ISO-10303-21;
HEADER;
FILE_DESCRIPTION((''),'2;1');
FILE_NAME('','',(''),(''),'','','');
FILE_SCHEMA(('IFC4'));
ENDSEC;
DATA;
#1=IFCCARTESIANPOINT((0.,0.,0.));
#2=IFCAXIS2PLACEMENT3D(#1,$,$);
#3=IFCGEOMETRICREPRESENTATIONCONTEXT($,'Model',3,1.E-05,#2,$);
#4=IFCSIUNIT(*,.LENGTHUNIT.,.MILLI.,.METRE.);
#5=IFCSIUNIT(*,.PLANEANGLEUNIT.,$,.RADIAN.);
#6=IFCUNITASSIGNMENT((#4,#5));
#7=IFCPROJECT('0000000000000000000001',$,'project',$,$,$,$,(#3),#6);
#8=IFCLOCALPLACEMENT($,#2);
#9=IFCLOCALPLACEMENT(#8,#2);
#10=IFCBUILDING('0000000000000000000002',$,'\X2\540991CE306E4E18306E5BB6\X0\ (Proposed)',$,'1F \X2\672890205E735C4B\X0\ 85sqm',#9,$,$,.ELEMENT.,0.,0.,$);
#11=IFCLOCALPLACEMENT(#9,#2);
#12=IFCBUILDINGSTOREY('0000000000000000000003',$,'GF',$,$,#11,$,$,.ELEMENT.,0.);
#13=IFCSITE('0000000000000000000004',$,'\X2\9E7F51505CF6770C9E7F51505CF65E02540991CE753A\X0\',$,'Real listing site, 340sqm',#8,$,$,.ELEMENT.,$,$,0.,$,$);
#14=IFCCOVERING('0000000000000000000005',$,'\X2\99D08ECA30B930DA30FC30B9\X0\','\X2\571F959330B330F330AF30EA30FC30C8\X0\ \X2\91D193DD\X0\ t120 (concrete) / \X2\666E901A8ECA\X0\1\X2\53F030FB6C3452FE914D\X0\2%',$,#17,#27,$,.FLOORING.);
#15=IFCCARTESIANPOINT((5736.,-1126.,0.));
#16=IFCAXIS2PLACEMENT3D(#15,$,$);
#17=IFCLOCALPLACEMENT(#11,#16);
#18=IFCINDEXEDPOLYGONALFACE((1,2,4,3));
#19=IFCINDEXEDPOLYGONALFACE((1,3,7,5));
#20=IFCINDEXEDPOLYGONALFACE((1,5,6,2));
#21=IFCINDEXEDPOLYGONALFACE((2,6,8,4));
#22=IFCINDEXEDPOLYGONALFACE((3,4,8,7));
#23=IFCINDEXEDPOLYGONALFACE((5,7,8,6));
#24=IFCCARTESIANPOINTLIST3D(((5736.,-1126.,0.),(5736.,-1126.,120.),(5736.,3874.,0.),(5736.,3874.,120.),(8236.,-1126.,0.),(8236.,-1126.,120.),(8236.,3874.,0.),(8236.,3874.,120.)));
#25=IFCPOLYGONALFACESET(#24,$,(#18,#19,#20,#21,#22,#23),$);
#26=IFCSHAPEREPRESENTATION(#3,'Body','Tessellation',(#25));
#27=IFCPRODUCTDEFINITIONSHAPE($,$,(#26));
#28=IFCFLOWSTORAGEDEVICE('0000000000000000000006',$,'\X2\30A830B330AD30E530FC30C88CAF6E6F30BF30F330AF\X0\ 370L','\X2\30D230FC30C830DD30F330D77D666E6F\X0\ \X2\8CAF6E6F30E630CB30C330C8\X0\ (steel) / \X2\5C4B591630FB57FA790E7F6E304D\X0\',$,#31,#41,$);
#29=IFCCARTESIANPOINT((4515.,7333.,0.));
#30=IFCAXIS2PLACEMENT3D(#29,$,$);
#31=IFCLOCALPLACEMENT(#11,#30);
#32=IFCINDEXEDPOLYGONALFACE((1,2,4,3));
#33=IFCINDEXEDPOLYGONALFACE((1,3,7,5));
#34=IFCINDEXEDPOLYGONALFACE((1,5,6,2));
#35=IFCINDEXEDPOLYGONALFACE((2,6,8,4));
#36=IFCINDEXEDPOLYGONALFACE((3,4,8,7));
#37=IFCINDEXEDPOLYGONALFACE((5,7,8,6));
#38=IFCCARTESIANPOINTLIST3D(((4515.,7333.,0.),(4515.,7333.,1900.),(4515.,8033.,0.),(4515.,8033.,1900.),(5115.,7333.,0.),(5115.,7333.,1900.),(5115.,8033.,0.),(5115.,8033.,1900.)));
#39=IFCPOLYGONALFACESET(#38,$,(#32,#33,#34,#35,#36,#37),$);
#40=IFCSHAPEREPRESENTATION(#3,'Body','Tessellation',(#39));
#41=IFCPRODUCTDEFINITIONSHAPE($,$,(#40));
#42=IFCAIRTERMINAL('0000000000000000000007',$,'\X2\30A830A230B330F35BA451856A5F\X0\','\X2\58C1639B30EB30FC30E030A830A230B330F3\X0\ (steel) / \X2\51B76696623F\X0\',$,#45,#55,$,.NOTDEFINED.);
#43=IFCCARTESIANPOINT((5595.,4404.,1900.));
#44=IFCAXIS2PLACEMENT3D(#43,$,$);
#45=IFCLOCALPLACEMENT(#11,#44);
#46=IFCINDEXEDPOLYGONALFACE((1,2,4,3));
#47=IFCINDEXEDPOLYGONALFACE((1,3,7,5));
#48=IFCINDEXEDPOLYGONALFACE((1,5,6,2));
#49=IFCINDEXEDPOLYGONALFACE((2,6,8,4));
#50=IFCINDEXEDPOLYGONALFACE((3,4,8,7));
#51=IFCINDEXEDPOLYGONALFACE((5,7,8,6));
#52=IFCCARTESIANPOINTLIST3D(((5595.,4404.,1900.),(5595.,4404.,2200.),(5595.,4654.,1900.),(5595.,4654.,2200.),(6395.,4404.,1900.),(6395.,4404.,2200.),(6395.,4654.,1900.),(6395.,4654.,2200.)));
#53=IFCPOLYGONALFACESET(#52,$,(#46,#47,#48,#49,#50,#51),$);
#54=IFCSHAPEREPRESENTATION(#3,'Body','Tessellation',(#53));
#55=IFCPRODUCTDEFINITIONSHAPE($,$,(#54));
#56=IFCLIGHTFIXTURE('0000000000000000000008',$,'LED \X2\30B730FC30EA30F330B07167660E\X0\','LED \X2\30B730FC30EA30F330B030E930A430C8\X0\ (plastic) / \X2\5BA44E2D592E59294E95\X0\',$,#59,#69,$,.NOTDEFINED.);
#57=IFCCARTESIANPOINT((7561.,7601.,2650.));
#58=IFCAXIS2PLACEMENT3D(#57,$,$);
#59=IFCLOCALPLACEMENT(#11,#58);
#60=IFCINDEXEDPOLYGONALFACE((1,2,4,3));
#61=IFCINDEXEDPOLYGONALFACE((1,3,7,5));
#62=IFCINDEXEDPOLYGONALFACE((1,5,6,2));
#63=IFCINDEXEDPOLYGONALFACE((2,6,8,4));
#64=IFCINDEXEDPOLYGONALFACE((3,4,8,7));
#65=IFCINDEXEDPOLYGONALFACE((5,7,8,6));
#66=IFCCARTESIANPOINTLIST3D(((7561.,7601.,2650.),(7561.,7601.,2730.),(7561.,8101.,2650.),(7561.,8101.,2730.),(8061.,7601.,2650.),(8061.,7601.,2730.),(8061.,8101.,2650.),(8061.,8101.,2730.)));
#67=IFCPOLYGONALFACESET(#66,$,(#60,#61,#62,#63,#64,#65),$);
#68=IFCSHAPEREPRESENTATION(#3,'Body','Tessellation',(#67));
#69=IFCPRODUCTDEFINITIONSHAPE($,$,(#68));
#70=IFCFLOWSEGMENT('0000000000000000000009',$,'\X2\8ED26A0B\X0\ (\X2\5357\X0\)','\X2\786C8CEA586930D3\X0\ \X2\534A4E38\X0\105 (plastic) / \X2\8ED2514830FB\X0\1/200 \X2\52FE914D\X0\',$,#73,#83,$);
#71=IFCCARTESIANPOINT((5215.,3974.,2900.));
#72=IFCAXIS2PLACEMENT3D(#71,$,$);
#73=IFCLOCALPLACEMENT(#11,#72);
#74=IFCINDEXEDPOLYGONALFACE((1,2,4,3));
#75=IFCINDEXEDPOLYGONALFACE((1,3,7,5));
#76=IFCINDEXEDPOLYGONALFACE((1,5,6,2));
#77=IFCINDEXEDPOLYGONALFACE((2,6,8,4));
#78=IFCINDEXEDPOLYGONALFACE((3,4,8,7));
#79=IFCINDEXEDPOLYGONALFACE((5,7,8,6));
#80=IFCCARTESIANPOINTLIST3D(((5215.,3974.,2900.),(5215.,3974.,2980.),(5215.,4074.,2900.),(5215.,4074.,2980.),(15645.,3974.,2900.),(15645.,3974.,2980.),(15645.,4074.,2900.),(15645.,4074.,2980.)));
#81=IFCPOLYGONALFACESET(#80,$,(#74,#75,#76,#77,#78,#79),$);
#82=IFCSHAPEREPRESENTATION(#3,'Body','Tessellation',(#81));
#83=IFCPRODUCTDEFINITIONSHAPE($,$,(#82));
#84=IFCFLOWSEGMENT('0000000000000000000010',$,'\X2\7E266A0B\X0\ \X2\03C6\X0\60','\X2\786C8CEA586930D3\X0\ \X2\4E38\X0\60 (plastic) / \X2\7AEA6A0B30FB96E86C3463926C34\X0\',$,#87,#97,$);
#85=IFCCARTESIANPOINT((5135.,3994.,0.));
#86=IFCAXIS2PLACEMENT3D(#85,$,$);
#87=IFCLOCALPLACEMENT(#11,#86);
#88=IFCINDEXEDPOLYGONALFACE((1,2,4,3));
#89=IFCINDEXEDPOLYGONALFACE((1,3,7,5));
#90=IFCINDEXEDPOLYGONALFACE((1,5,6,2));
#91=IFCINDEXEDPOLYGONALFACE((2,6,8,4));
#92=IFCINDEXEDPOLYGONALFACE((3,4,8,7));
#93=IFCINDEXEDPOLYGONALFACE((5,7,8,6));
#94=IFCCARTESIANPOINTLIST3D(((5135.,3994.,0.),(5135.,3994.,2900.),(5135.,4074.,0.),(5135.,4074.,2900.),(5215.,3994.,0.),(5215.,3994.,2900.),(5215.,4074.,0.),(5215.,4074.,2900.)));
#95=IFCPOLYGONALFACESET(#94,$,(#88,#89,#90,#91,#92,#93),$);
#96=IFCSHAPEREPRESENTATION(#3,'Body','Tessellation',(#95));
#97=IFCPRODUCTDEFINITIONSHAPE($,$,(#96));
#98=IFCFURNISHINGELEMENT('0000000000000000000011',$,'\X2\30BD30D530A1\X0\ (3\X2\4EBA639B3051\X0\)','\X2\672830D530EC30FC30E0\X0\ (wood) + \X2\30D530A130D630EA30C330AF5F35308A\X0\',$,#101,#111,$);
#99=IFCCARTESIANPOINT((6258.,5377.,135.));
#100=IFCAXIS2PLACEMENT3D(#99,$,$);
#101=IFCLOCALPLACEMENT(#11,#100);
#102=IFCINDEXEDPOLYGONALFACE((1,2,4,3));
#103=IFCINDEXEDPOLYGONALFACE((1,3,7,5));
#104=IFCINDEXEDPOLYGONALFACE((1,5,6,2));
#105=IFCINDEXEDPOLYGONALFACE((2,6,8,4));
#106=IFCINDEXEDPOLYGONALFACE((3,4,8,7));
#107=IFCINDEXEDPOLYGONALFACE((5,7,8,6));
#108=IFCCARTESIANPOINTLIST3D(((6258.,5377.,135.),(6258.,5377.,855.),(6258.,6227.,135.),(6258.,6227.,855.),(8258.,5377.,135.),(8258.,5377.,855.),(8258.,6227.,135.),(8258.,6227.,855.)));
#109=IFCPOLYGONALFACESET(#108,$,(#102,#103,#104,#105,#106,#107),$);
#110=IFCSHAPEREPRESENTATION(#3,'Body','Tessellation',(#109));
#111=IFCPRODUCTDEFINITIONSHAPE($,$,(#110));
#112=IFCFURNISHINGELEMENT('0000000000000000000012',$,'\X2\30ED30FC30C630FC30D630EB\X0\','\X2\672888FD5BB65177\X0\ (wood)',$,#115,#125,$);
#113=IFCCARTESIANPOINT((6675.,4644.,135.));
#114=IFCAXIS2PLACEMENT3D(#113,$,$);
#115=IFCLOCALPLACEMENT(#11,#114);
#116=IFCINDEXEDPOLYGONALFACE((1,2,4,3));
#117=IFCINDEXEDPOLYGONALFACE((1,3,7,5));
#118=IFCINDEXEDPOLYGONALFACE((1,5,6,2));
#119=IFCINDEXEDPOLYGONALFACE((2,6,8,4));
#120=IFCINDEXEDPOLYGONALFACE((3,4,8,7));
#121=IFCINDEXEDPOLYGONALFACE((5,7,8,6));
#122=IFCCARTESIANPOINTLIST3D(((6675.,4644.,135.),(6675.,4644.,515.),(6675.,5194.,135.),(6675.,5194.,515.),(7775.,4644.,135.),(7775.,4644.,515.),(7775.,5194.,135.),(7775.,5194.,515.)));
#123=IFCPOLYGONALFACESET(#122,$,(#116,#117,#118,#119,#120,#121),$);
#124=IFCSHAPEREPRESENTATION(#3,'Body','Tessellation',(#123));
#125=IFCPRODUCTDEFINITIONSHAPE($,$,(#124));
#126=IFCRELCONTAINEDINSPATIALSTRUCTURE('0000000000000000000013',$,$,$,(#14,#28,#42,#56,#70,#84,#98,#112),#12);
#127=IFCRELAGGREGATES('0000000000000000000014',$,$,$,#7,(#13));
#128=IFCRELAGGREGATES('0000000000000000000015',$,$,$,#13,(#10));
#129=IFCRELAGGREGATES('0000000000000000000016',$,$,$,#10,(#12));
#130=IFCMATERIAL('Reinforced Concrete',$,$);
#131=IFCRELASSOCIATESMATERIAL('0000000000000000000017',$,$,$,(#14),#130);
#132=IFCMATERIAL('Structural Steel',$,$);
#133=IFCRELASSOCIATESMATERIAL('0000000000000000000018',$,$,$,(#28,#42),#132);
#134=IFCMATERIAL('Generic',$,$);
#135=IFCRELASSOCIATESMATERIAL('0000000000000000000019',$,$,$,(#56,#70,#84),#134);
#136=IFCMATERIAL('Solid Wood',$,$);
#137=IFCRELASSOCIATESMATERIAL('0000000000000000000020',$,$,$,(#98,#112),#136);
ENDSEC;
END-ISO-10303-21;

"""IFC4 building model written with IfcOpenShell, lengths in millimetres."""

from ifc_helpers import new_model, si_unit, frame, frame_2d, origin, place, context, project, spatial, rectangle, extrude, material, element, save


model = new_model("IFC4")

# Units and contexts
model_context = context("Model", 3, precision=1e-05, world=origin())
ifc_project = project(units=[si_unit("LENGTHUNIT", "METRE", prefix="MILLI"), si_unit("PLANEANGLEUNIT", "RADIAN")], contexts=[model_context])

# Site, building, storey
site_placement = place(None, origin())
site = spatial("IfcSite", under=ifc_project, at=site_placement, Name="鹿児島県鹿児島市吉野町", ObjectType="Real listing site, 340sqm", CompositionType="ELEMENT", RefElevation=0.0)
building_placement = place(site_placement, origin())
building = spatial("IfcBuilding", under=site, at=building_placement, Name="吉野の丘の家 (Proposed)", ObjectType="1F 木造平屋 85sqm", CompositionType="ELEMENT", ElevationOfRefHeight=0.0, ElevationOfTerrain=0.0)
storey_placement = place(building_placement, origin())
storey = spatial("IfcBuildingStorey", under=building, at=storey_placement, Name="GF", CompositionType="ELEMENT", Elevation=0.0)

# Shared definitions
ifc_material_1 = material(Name="Solid Wood")

# Shared definitions
ifc_material_2 = material(Name="Reinforced Concrete")

# Shared definitions
ifc_material_3 = material(Name="Structural Steel")

# Covering
ifc_material_4 = material(Name="Generic")
covering_1_placement = place(storey_placement, frame((5736.0, -1126.0, 0.0)))
element("IfcCovering", 1, at=covering_1_placement, inside=storey, material=ifc_material_2, Name="駐車スペース", Description="土間コンクリート 金鏝 t120 (concrete) / 普通車1台・水勾配2%", PredefinedType="FLOORING", context=model_context, shape_type="SweptSolid", body=[
    extrude(rectangle(XDim=2500.0, YDim=5000.0, at=frame_2d((1250.0, 2500.0))), frame((5736.0, -1126.0, 0.0)), (0.0, 0.0, 1.0), 120.0),
])

# Flow storage device
flow_storage_device_placement = place(storey_placement, frame((4515.0, 7333.0, 0.0)))
element("IfcFlowStorageDevice", 2, at=flow_storage_device_placement, inside=storey, material=ifc_material_3, Name="エコキュート貯湯タンク 370L", Description="ヒートポンプ給湯 貯湯ユニット (steel) / 屋外・基礎置き", context=model_context, shape_type="SweptSolid", body=[
    extrude(rectangle(XDim=600.0, YDim=700.0, at=frame_2d((300.0, 350.0))), frame((4515.0, 7333.0, 0.0)), (0.0, 0.0, 1.0), 1900.0),
])

# Air terminal
air_terminal_placement = place(storey_placement, frame((5595.0, 4404.0, 1900.0)))
element("IfcAirTerminal", 3, at=air_terminal_placement, inside=storey, material=ifc_material_3, Name="エアコン室内機", Description="壁掛ルームエアコン (steel) / 冷暖房", PredefinedType="NOTDEFINED", context=model_context, shape_type="SweptSolid", body=[
    extrude(rectangle(XDim=800.0, YDim=250.0, at=frame_2d((400.0, 125.0))), frame((5595.0, 4404.0, 1900.0)), (0.0, 0.0, 1.0), 300.0),
])

# Light fixture
light_fixture_placement = place(storey_placement, frame((7561.0, 7601.0, 2650.0)))
element("IfcLightFixture", 4, at=light_fixture_placement, inside=storey, material=ifc_material_4, Name="LED シーリング照明", Description="LED シーリングライト (plastic) / 室中央天井", PredefinedType="NOTDEFINED", context=model_context, shape_type="SweptSolid", body=[
    extrude(rectangle(XDim=500.0, YDim=500.0, at=frame_2d((250.0, 250.0))), frame((7561.0, 7601.0, 2650.0)), (0.0, 0.0, 1.0), 80.0),
])

# Flow segments
flow_segment_1_placement = place(storey_placement, frame((5215.0, 3974.0, 2900.0)))
element("IfcFlowSegment", 5, at=flow_segment_1_placement, inside=storey, material=ifc_material_4, Name="軒樋 (南)", Description="硬質塩ビ 半丸105 (plastic) / 軒先・1/200 勾配", context=model_context, shape_type="SweptSolid", body=[
    extrude(rectangle(XDim=10430.0, YDim=100.0, at=frame_2d((5215.0, 50.0))), frame((5215.0, 3974.0, 2900.0)), (0.0, 0.0, 1.0), 80.0),
])
flow_segment_2_placement = place(storey_placement, frame((5135.0, 3994.0, 0.0)))
element("IfcFlowSegment", 6, at=flow_segment_2_placement, inside=storey, material=ifc_material_4, Name="縦樋 φ60", Description="硬質塩ビ 丸60 (plastic) / 竪樋・雨水排水", context=model_context, shape_type="SweptSolid", body=[
    extrude(rectangle(XDim=80.0, YDim=80.0, at=frame_2d((40.0, 40.0))), frame((5135.0, 3994.0, 0.0)), (0.0, 0.0, 1.0), 2900.0),
])

# Furnishing elements
furnishing_1_placement = place(storey_placement, frame((6258.0, 5377.0, 135.0)))
element("IfcFurnishingElement", 7, at=furnishing_1_placement, inside=storey, material=ifc_material_1, Name="ソファ (3人掛け)", Description="木フレーム (wood) + ファブリック張り", context=model_context, shape_type="SweptSolid", body=[
    extrude(rectangle(XDim=2000.0, YDim=850.0, at=frame_2d((1000.0, 425.0))), frame((6258.0, 5377.0, 135.0)), (0.0, 0.0, 1.0), 720.0),
])
furnishing_2_placement = place(storey_placement, frame((6675.0, 4644.0, 135.0)))
element("IfcFurnishingElement", 8, at=furnishing_2_placement, inside=storey, material=ifc_material_1, Name="ローテーブル", Description="木製家具 (wood)", context=model_context, shape_type="SweptSolid", body=[
    extrude(rectangle(XDim=1100.0, YDim=550.0, at=frame_2d((550.0, 275.0))), frame((6675.0, 4644.0, 135.0)), (0.0, 0.0, 1.0), 380.0),
])

save(model, "model.ifc")
